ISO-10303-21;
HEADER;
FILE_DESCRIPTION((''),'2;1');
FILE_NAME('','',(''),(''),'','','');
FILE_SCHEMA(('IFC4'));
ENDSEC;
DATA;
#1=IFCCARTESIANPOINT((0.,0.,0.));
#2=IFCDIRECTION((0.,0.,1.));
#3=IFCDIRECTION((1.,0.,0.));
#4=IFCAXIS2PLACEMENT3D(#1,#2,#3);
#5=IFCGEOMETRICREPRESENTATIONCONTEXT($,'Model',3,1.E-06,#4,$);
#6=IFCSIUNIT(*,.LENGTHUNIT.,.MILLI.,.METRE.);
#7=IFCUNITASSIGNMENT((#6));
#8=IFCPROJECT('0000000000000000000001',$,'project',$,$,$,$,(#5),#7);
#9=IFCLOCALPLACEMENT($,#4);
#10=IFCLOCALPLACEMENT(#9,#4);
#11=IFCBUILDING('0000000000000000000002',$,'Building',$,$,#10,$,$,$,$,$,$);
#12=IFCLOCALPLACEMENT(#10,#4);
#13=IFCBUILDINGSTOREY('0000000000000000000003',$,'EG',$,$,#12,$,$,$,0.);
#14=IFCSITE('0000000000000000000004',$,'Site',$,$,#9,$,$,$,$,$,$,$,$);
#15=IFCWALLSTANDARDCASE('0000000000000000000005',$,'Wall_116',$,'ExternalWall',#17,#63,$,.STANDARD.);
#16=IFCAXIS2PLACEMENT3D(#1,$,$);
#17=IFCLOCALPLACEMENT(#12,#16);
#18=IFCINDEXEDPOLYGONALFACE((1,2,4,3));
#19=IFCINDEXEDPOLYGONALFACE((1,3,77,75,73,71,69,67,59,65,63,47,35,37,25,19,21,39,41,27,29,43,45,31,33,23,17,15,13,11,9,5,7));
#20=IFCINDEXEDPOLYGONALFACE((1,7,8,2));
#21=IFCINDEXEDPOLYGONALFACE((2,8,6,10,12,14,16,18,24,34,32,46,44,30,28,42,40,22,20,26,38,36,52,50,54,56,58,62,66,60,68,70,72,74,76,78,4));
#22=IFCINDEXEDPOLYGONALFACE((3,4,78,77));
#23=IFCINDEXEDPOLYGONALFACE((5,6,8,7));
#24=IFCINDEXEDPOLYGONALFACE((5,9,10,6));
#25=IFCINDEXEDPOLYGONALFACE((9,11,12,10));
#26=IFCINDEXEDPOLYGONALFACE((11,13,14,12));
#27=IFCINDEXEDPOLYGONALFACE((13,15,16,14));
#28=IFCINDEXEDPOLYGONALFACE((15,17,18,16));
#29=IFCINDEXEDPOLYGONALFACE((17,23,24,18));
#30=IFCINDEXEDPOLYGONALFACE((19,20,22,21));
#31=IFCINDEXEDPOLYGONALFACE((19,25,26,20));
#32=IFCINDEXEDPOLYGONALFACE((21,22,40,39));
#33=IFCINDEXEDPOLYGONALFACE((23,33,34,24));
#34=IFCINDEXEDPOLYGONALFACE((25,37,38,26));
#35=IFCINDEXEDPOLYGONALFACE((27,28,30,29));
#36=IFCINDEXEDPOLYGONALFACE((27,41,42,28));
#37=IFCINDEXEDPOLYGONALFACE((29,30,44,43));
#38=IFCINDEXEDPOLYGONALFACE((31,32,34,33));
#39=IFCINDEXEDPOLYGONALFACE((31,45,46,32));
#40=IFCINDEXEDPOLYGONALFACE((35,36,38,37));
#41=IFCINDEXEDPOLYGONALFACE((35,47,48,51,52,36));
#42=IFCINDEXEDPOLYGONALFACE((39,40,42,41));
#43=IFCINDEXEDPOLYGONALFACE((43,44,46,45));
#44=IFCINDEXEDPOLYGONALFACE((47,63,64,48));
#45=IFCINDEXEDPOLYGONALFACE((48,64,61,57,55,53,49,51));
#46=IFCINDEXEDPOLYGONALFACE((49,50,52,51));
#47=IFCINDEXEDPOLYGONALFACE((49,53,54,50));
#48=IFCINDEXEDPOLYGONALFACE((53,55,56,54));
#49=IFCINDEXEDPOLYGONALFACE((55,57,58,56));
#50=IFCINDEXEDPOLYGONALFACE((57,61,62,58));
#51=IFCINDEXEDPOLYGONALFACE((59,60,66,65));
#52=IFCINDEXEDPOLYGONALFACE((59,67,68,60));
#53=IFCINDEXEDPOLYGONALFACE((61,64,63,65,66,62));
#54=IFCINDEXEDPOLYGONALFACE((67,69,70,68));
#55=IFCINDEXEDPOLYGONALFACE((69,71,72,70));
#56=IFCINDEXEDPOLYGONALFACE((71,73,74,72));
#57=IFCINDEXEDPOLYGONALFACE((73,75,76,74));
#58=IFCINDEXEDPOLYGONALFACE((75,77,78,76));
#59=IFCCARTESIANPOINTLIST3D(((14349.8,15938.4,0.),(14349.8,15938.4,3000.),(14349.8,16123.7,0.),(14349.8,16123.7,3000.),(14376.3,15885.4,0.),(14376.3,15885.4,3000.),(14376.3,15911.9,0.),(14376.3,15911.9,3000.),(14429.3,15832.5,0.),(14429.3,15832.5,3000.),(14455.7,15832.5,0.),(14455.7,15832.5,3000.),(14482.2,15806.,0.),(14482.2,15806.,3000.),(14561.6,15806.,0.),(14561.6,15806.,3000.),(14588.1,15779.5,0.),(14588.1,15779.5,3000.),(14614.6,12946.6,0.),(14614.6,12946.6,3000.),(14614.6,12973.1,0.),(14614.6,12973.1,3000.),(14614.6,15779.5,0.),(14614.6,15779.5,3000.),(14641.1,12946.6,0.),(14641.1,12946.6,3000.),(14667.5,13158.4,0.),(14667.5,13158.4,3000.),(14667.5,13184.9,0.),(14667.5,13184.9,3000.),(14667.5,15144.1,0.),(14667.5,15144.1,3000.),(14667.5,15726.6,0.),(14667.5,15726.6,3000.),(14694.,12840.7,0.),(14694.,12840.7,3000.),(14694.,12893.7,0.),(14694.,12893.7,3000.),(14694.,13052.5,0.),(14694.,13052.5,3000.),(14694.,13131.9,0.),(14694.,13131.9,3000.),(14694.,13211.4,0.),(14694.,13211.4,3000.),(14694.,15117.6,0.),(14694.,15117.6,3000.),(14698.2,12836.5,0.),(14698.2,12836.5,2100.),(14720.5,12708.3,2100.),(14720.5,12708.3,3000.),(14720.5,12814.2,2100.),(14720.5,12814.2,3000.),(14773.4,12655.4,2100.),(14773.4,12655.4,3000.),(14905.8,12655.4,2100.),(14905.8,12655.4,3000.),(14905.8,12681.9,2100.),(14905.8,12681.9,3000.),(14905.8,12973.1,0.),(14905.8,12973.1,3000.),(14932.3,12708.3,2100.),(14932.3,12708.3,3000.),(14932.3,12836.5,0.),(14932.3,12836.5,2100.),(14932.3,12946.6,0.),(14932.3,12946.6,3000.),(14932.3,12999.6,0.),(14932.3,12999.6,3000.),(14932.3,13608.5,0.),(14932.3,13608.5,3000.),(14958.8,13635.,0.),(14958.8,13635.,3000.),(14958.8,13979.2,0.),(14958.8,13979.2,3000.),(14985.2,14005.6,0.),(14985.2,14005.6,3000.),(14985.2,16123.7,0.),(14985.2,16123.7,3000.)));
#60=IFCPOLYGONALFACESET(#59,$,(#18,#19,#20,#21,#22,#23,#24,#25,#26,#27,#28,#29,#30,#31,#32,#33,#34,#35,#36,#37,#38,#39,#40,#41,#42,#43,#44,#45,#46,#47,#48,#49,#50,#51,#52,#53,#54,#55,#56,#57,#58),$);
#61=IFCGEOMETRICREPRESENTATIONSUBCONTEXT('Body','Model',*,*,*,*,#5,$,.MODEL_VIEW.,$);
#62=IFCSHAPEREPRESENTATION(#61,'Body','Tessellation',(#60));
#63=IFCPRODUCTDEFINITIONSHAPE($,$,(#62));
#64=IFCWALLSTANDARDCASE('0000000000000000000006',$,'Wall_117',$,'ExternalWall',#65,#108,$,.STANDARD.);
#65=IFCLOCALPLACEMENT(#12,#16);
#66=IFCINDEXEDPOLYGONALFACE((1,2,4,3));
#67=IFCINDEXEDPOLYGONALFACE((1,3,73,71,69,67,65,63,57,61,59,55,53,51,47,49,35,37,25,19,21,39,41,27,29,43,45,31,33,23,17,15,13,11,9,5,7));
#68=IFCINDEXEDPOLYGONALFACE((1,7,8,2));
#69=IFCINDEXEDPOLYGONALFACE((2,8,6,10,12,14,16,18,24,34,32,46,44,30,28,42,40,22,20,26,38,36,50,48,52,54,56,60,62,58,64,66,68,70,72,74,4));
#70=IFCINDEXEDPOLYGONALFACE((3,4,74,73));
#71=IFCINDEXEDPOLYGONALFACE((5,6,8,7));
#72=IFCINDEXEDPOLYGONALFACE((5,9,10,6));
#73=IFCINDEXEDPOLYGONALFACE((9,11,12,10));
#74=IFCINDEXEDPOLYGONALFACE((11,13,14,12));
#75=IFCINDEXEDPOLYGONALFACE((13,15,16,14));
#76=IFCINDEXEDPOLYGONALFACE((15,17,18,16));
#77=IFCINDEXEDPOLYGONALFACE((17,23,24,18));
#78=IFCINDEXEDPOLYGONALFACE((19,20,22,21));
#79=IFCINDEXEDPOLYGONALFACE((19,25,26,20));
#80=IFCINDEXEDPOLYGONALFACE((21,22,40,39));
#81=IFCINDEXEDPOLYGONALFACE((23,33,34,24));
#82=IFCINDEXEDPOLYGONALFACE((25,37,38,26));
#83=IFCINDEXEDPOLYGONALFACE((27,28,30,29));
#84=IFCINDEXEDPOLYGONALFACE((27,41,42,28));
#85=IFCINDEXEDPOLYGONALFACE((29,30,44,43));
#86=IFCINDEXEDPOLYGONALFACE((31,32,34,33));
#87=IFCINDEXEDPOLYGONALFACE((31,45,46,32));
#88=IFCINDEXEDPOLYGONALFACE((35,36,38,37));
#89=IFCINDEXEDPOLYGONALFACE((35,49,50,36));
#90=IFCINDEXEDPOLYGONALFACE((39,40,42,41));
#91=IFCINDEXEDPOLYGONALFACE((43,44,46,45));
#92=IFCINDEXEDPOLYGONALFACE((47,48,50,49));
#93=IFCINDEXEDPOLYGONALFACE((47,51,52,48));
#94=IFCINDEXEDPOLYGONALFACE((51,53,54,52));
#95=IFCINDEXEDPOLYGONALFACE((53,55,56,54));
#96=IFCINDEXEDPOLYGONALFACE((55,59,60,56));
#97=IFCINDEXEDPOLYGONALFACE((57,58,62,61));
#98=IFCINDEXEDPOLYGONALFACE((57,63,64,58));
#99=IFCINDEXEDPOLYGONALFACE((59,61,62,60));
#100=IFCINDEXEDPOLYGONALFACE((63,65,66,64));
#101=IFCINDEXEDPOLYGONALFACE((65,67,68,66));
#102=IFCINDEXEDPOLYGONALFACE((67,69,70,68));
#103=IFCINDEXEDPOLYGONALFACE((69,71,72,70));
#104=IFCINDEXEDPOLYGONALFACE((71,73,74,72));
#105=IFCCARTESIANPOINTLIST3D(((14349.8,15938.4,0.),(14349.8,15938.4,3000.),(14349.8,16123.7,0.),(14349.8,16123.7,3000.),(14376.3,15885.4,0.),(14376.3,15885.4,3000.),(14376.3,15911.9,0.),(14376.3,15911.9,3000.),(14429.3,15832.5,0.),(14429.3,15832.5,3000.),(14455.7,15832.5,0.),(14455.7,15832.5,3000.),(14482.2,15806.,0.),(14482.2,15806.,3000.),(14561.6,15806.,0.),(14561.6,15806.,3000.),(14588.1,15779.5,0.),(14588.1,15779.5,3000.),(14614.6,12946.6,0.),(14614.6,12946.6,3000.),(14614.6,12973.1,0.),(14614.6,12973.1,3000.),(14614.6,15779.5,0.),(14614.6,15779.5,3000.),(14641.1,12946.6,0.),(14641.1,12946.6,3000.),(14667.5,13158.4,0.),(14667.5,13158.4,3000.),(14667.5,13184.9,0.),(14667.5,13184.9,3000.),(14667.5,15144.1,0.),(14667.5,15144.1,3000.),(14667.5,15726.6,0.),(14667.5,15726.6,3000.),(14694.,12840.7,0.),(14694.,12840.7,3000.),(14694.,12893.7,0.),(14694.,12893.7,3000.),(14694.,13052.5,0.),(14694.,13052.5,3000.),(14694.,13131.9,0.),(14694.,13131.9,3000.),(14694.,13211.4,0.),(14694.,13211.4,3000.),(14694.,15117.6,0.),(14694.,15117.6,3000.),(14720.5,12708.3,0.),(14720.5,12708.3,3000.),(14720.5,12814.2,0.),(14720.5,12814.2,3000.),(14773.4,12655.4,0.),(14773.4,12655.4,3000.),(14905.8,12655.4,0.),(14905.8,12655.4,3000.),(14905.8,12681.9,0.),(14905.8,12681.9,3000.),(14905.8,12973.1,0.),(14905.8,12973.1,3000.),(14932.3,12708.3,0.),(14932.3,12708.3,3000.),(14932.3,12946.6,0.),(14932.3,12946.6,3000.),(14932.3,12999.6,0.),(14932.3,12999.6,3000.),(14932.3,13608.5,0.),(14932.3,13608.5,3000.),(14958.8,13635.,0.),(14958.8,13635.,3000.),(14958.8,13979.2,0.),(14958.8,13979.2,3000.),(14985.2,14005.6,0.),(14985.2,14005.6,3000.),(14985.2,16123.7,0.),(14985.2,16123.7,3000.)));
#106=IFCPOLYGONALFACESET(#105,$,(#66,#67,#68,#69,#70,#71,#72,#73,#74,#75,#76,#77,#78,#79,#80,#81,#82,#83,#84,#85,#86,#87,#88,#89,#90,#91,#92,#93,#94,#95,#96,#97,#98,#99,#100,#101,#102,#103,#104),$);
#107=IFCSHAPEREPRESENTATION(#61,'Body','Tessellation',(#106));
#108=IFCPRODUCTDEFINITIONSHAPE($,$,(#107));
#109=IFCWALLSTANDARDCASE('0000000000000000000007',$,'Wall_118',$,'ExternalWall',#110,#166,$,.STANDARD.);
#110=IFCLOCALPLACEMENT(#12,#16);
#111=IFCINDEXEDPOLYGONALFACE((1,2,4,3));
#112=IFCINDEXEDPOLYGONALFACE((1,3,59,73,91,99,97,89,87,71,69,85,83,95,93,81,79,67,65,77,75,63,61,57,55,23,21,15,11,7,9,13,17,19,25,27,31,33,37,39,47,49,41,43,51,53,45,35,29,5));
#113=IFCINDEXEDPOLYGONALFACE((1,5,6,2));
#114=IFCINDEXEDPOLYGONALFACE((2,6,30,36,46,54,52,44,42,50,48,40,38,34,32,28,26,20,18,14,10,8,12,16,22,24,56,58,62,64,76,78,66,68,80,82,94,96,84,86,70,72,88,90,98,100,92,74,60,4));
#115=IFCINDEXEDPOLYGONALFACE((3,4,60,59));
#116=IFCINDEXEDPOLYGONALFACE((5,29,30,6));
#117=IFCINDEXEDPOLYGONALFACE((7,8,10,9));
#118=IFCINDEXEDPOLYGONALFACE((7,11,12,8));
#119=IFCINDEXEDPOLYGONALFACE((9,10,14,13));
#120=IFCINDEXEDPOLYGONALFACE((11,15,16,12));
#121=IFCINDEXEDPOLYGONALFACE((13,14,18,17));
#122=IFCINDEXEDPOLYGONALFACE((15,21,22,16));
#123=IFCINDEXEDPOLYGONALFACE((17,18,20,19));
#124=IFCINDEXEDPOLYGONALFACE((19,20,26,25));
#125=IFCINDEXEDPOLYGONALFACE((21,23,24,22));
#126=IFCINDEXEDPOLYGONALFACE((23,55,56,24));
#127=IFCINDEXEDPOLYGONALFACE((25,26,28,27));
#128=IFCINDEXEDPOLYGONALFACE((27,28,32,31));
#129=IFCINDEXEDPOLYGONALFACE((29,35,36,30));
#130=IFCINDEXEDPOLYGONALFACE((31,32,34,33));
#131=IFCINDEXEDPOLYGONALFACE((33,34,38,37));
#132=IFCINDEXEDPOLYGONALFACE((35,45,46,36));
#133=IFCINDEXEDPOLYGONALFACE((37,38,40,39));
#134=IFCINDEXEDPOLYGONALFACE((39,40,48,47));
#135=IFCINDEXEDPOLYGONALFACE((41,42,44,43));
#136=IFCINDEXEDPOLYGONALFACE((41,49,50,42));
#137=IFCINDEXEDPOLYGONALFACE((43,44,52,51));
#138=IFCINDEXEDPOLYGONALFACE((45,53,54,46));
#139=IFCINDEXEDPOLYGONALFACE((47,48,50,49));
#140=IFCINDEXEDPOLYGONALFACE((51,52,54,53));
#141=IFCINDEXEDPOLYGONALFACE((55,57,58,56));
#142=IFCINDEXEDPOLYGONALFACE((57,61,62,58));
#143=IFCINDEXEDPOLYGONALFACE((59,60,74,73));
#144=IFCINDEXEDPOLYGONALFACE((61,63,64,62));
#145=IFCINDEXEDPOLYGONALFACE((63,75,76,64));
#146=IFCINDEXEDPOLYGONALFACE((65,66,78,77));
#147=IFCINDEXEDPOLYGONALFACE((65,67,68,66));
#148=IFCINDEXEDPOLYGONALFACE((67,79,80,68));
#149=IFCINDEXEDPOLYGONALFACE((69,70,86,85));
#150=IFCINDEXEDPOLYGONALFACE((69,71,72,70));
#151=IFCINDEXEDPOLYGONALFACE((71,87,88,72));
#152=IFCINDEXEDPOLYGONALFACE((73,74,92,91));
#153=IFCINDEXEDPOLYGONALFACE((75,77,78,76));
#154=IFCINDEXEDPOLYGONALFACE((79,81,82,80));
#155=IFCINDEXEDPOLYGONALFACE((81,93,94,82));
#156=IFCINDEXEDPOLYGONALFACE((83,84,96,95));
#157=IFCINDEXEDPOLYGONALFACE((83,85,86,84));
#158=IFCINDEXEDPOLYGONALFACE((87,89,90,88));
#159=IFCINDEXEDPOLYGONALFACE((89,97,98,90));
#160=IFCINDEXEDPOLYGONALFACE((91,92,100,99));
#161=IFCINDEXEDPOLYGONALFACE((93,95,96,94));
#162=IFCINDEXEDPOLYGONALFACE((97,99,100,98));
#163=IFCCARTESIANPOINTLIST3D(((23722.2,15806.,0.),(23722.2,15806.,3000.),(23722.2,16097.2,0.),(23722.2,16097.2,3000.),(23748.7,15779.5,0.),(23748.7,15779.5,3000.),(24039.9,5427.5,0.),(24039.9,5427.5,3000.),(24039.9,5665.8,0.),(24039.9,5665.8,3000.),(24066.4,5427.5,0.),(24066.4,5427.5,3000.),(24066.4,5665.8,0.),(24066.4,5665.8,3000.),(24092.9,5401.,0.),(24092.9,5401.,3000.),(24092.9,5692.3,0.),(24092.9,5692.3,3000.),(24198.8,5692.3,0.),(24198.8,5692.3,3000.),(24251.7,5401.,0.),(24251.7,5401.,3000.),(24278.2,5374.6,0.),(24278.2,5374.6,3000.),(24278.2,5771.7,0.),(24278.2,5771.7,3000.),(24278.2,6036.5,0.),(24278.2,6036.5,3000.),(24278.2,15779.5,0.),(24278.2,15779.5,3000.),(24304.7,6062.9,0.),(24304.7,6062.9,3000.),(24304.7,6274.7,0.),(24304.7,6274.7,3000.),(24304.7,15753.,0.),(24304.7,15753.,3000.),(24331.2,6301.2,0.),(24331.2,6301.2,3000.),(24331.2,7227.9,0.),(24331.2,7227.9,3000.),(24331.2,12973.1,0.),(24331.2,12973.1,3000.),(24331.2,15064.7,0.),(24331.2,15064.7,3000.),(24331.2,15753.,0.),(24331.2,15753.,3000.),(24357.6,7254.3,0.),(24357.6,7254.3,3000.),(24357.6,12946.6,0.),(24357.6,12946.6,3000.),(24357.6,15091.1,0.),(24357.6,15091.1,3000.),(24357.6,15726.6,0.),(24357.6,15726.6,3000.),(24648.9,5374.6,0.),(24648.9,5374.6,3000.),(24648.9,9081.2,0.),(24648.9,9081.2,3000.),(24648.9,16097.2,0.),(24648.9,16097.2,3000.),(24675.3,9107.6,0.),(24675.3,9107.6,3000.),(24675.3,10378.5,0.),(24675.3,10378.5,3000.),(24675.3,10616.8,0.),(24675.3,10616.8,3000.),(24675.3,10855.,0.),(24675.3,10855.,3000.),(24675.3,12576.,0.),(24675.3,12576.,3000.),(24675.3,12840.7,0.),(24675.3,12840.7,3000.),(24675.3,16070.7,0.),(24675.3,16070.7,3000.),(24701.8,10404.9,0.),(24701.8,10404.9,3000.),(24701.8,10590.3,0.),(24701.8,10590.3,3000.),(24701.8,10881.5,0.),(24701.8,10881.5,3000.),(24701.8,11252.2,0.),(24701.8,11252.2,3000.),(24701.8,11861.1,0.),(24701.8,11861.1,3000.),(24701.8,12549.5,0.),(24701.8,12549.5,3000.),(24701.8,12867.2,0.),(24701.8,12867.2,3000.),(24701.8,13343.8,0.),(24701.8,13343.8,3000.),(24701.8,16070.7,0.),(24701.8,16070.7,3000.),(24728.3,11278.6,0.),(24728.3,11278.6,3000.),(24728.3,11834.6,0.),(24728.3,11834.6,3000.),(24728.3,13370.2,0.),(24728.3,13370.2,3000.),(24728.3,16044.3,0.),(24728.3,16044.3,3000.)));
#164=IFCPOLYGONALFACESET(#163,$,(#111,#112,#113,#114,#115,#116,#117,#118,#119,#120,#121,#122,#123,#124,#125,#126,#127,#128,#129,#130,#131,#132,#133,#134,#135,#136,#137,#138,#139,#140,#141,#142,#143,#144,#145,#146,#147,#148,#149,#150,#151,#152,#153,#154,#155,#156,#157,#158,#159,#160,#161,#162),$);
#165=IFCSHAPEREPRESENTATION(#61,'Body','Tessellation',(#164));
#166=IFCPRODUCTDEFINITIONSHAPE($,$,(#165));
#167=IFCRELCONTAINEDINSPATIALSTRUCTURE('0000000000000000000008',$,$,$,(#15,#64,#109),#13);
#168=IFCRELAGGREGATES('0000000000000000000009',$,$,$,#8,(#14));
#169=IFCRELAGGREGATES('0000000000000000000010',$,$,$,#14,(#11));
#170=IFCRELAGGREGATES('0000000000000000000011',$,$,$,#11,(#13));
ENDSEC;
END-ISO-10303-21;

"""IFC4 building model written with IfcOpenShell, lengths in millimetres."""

from ifc_helpers import new_model, si_unit, frame, origin_with_axes, place, context, subcontext, project, spatial, polyline, rectangle, outline, extrude, element, save


model = new_model("IFC4")

# Units and contexts
model_context = context("Model", 3, precision=1e-06, world=origin_with_axes())
body_context = subcontext(model_context, "Body", "Model", "MODEL_VIEW")
ifc_project = project(units=[si_unit("LENGTHUNIT", "METRE", prefix="MILLI")], contexts=[model_context])

# Site, building, storey
site_placement = place(None, origin_with_axes())
site = spatial("IfcSite", under=ifc_project, at=site_placement, Name="Site")
building_placement = place(site_placement, origin_with_axes())
building = spatial("IfcBuilding", under=site, at=building_placement, Name="Building")
storey_placement = place(building_placement, origin_with_axes())
storey = spatial("IfcBuildingStorey", under=building, at=storey_placement, Name="EG", Elevation=0.0)

# Wall, opening
wall_1_placement = place(storey_placement, origin_with_axes())
wall_1 = element("IfcWallStandardCase", 1, at=wall_1_placement, inside=storey, Name="Wall_116", ObjectType="ExternalWall", PredefinedType="STANDARD", context=body_context, shape_type="SweptSolid", body=[
    extrude(outline(polyline([(14773.4, 12655.4, 0.0), (14720.5, 12708.3, 0.0), (14720.5, 12814.2, 0.0), (14694.0, 12840.7, 0.0), (14694.0, 12893.7, 0.0), (14641.1, 12946.6, 0.0), (14614.6, 12946.6, 0.0), (14614.6, 12973.1, 0.0), (14694.0, 13052.5, 0.0), (14694.0, 13131.9, 0.0), (14667.5, 13158.4, 0.0), (14667.5, 13184.9, 0.0), (14694.0, 13211.4, 0.0), (14694.0, 15117.6, 0.0), (14667.5, 15144.1, 0.0), (14667.5, 15726.6, 0.0), (14614.6, 15779.5, 0.0), (14588.1, 15779.5, 0.0), (14561.6, 15806.0, 0.0), (14482.2, 15806.0, 0.0), (14455.7, 15832.5, 0.0), (14429.3, 15832.5, 0.0), (14376.3, 15885.4, 0.0), (14376.3, 15911.9, 0.0), (14349.8, 15938.4, 0.0), (14349.8, 16123.7, 0.0), (14985.2, 16123.7, 0.0), (14985.2, 14005.6, 0.0), (14958.8, 13979.2, 0.0), (14958.8, 13635.0, 0.0), (14932.3, 13608.5, 0.0), (14932.3, 12999.6, 0.0), (14905.8, 12973.1, 0.0), (14932.3, 12946.6, 0.0), (14932.3, 12708.3, 0.0), (14905.8, 12681.9, 0.0), (14905.8, 12655.4, 0.0), (14773.4, 12655.4, 0.0)])), origin_with_axes(), (0.0, 0.0, 1.0), 3000.0),
])
opening_1_placement = place(wall_1_placement, origin_with_axes())
element("IfcOpeningElement", 2, at=opening_1_placement, inside=storey, cuts=wall_1, context=body_context, shape_type="SweptSolid", body=[
    extrude(rectangle(XDim=1059.0, YDim=240.0), frame((14455.7, 12716.5, 0.0), z_axis=(0.0, 0.0, 1.0), x_axis=(1.0, 0.0, 0.0)), (0.0, 0.0, 1.0), 2100.0),
])

# Walls
wall_2_placement = place(storey_placement, origin_with_axes())
element("IfcWallStandardCase", 3, at=wall_2_placement, inside=storey, Name="Wall_117", ObjectType="ExternalWall", PredefinedType="STANDARD", context=body_context, shape_type="SweptSolid", body=[
    extrude(outline(polyline([(14773.4, 12655.4, 0.0), (14720.5, 12708.3, 0.0), (14720.5, 12814.2, 0.0), (14694.0, 12840.7, 0.0), (14694.0, 12893.7, 0.0), (14641.1, 12946.6, 0.0), (14614.6, 12946.6, 0.0), (14614.6, 12973.1, 0.0), (14694.0, 13052.5, 0.0), (14694.0, 13131.9, 0.0), (14667.5, 13158.4, 0.0), (14667.5, 13184.9, 0.0), (14694.0, 13211.4, 0.0), (14694.0, 15117.6, 0.0), (14667.5, 15144.1, 0.0), (14667.5, 15726.6, 0.0), (14614.6, 15779.5, 0.0), (14588.1, 15779.5, 0.0), (14561.6, 15806.0, 0.0), (14482.2, 15806.0, 0.0), (14455.7, 15832.5, 0.0), (14429.3, 15832.5, 0.0), (14376.3, 15885.4, 0.0), (14376.3, 15911.9, 0.0), (14349.8, 15938.4, 0.0), (14349.8, 16123.7, 0.0), (14985.2, 16123.7, 0.0), (14985.2, 14005.6, 0.0), (14958.8, 13979.2, 0.0), (14958.8, 13635.0, 0.0), (14932.3, 13608.5, 0.0), (14932.3, 12999.6, 0.0), (14905.8, 12973.1, 0.0), (14932.3, 12946.6, 0.0), (14932.3, 12708.3, 0.0), (14905.8, 12681.9, 0.0), (14905.8, 12655.4, 0.0), (14773.4, 12655.4, 0.0)])), origin_with_axes(), (0.0, 0.0, 1.0), 3000.0),
])
wall_3_placement = place(storey_placement, origin_with_axes())
element("IfcWallStandardCase", 4, at=wall_3_placement, inside=storey, Name="Wall_118", ObjectType="ExternalWall", PredefinedType="STANDARD", context=body_context, shape_type="SweptSolid", body=[
    extrude(outline(polyline([(24278.2, 5374.6, 0.0), (24251.7, 5401.0, 0.0), (24092.9, 5401.0, 0.0), (24066.4, 5427.5, 0.0), (24039.9, 5427.5, 0.0), (24039.9, 5665.8, 0.0), (24066.4, 5665.8, 0.0), (24092.9, 5692.3, 0.0), (24198.8, 5692.3, 0.0), (24278.2, 5771.7, 0.0), (24278.2, 6036.5, 0.0), (24304.7, 6062.9, 0.0), (24304.7, 6274.7, 0.0), (24331.2, 6301.2, 0.0), (24331.2, 7227.9, 0.0), (24357.6, 7254.3, 0.0), (24357.6, 12946.6, 0.0), (24331.2, 12973.1, 0.0), (24331.2, 15064.7, 0.0), (24357.6, 15091.1, 0.0), (24357.6, 15726.6, 0.0), (24331.2, 15753.0, 0.0), (24304.7, 15753.0, 0.0), (24278.2, 15779.5, 0.0), (23748.7, 15779.5, 0.0), (23722.2, 15806.0, 0.0), (23722.2, 16097.2, 0.0), (24648.9, 16097.2, 0.0), (24675.3, 16070.7, 0.0), (24701.8, 16070.7, 0.0), (24728.3, 16044.3, 0.0), (24728.3, 13370.2, 0.0), (24701.8, 13343.8, 0.0), (24701.8, 12867.2, 0.0), (24675.3, 12840.7, 0.0), (24675.3, 12576.0, 0.0), (24701.8, 12549.5, 0.0), (24701.8, 11861.1, 0.0), (24728.3, 11834.6, 0.0), (24728.3, 11278.6, 0.0), (24701.8, 11252.2, 0.0), (24701.8, 10881.5, 0.0), (24675.3, 10855.0, 0.0), (24675.3, 10616.8, 0.0), (24701.8, 10590.3, 0.0), (24701.8, 10404.9, 0.0), (24675.3, 10378.5, 0.0), (24675.3, 9107.6, 0.0), (24648.9, 9081.2, 0.0), (24648.9, 5374.6, 0.0), (24278.2, 5374.6, 0.0)])), origin_with_axes(), (0.0, 0.0, 1.0), 3000.0),
])

save(model, "model.ifc")
